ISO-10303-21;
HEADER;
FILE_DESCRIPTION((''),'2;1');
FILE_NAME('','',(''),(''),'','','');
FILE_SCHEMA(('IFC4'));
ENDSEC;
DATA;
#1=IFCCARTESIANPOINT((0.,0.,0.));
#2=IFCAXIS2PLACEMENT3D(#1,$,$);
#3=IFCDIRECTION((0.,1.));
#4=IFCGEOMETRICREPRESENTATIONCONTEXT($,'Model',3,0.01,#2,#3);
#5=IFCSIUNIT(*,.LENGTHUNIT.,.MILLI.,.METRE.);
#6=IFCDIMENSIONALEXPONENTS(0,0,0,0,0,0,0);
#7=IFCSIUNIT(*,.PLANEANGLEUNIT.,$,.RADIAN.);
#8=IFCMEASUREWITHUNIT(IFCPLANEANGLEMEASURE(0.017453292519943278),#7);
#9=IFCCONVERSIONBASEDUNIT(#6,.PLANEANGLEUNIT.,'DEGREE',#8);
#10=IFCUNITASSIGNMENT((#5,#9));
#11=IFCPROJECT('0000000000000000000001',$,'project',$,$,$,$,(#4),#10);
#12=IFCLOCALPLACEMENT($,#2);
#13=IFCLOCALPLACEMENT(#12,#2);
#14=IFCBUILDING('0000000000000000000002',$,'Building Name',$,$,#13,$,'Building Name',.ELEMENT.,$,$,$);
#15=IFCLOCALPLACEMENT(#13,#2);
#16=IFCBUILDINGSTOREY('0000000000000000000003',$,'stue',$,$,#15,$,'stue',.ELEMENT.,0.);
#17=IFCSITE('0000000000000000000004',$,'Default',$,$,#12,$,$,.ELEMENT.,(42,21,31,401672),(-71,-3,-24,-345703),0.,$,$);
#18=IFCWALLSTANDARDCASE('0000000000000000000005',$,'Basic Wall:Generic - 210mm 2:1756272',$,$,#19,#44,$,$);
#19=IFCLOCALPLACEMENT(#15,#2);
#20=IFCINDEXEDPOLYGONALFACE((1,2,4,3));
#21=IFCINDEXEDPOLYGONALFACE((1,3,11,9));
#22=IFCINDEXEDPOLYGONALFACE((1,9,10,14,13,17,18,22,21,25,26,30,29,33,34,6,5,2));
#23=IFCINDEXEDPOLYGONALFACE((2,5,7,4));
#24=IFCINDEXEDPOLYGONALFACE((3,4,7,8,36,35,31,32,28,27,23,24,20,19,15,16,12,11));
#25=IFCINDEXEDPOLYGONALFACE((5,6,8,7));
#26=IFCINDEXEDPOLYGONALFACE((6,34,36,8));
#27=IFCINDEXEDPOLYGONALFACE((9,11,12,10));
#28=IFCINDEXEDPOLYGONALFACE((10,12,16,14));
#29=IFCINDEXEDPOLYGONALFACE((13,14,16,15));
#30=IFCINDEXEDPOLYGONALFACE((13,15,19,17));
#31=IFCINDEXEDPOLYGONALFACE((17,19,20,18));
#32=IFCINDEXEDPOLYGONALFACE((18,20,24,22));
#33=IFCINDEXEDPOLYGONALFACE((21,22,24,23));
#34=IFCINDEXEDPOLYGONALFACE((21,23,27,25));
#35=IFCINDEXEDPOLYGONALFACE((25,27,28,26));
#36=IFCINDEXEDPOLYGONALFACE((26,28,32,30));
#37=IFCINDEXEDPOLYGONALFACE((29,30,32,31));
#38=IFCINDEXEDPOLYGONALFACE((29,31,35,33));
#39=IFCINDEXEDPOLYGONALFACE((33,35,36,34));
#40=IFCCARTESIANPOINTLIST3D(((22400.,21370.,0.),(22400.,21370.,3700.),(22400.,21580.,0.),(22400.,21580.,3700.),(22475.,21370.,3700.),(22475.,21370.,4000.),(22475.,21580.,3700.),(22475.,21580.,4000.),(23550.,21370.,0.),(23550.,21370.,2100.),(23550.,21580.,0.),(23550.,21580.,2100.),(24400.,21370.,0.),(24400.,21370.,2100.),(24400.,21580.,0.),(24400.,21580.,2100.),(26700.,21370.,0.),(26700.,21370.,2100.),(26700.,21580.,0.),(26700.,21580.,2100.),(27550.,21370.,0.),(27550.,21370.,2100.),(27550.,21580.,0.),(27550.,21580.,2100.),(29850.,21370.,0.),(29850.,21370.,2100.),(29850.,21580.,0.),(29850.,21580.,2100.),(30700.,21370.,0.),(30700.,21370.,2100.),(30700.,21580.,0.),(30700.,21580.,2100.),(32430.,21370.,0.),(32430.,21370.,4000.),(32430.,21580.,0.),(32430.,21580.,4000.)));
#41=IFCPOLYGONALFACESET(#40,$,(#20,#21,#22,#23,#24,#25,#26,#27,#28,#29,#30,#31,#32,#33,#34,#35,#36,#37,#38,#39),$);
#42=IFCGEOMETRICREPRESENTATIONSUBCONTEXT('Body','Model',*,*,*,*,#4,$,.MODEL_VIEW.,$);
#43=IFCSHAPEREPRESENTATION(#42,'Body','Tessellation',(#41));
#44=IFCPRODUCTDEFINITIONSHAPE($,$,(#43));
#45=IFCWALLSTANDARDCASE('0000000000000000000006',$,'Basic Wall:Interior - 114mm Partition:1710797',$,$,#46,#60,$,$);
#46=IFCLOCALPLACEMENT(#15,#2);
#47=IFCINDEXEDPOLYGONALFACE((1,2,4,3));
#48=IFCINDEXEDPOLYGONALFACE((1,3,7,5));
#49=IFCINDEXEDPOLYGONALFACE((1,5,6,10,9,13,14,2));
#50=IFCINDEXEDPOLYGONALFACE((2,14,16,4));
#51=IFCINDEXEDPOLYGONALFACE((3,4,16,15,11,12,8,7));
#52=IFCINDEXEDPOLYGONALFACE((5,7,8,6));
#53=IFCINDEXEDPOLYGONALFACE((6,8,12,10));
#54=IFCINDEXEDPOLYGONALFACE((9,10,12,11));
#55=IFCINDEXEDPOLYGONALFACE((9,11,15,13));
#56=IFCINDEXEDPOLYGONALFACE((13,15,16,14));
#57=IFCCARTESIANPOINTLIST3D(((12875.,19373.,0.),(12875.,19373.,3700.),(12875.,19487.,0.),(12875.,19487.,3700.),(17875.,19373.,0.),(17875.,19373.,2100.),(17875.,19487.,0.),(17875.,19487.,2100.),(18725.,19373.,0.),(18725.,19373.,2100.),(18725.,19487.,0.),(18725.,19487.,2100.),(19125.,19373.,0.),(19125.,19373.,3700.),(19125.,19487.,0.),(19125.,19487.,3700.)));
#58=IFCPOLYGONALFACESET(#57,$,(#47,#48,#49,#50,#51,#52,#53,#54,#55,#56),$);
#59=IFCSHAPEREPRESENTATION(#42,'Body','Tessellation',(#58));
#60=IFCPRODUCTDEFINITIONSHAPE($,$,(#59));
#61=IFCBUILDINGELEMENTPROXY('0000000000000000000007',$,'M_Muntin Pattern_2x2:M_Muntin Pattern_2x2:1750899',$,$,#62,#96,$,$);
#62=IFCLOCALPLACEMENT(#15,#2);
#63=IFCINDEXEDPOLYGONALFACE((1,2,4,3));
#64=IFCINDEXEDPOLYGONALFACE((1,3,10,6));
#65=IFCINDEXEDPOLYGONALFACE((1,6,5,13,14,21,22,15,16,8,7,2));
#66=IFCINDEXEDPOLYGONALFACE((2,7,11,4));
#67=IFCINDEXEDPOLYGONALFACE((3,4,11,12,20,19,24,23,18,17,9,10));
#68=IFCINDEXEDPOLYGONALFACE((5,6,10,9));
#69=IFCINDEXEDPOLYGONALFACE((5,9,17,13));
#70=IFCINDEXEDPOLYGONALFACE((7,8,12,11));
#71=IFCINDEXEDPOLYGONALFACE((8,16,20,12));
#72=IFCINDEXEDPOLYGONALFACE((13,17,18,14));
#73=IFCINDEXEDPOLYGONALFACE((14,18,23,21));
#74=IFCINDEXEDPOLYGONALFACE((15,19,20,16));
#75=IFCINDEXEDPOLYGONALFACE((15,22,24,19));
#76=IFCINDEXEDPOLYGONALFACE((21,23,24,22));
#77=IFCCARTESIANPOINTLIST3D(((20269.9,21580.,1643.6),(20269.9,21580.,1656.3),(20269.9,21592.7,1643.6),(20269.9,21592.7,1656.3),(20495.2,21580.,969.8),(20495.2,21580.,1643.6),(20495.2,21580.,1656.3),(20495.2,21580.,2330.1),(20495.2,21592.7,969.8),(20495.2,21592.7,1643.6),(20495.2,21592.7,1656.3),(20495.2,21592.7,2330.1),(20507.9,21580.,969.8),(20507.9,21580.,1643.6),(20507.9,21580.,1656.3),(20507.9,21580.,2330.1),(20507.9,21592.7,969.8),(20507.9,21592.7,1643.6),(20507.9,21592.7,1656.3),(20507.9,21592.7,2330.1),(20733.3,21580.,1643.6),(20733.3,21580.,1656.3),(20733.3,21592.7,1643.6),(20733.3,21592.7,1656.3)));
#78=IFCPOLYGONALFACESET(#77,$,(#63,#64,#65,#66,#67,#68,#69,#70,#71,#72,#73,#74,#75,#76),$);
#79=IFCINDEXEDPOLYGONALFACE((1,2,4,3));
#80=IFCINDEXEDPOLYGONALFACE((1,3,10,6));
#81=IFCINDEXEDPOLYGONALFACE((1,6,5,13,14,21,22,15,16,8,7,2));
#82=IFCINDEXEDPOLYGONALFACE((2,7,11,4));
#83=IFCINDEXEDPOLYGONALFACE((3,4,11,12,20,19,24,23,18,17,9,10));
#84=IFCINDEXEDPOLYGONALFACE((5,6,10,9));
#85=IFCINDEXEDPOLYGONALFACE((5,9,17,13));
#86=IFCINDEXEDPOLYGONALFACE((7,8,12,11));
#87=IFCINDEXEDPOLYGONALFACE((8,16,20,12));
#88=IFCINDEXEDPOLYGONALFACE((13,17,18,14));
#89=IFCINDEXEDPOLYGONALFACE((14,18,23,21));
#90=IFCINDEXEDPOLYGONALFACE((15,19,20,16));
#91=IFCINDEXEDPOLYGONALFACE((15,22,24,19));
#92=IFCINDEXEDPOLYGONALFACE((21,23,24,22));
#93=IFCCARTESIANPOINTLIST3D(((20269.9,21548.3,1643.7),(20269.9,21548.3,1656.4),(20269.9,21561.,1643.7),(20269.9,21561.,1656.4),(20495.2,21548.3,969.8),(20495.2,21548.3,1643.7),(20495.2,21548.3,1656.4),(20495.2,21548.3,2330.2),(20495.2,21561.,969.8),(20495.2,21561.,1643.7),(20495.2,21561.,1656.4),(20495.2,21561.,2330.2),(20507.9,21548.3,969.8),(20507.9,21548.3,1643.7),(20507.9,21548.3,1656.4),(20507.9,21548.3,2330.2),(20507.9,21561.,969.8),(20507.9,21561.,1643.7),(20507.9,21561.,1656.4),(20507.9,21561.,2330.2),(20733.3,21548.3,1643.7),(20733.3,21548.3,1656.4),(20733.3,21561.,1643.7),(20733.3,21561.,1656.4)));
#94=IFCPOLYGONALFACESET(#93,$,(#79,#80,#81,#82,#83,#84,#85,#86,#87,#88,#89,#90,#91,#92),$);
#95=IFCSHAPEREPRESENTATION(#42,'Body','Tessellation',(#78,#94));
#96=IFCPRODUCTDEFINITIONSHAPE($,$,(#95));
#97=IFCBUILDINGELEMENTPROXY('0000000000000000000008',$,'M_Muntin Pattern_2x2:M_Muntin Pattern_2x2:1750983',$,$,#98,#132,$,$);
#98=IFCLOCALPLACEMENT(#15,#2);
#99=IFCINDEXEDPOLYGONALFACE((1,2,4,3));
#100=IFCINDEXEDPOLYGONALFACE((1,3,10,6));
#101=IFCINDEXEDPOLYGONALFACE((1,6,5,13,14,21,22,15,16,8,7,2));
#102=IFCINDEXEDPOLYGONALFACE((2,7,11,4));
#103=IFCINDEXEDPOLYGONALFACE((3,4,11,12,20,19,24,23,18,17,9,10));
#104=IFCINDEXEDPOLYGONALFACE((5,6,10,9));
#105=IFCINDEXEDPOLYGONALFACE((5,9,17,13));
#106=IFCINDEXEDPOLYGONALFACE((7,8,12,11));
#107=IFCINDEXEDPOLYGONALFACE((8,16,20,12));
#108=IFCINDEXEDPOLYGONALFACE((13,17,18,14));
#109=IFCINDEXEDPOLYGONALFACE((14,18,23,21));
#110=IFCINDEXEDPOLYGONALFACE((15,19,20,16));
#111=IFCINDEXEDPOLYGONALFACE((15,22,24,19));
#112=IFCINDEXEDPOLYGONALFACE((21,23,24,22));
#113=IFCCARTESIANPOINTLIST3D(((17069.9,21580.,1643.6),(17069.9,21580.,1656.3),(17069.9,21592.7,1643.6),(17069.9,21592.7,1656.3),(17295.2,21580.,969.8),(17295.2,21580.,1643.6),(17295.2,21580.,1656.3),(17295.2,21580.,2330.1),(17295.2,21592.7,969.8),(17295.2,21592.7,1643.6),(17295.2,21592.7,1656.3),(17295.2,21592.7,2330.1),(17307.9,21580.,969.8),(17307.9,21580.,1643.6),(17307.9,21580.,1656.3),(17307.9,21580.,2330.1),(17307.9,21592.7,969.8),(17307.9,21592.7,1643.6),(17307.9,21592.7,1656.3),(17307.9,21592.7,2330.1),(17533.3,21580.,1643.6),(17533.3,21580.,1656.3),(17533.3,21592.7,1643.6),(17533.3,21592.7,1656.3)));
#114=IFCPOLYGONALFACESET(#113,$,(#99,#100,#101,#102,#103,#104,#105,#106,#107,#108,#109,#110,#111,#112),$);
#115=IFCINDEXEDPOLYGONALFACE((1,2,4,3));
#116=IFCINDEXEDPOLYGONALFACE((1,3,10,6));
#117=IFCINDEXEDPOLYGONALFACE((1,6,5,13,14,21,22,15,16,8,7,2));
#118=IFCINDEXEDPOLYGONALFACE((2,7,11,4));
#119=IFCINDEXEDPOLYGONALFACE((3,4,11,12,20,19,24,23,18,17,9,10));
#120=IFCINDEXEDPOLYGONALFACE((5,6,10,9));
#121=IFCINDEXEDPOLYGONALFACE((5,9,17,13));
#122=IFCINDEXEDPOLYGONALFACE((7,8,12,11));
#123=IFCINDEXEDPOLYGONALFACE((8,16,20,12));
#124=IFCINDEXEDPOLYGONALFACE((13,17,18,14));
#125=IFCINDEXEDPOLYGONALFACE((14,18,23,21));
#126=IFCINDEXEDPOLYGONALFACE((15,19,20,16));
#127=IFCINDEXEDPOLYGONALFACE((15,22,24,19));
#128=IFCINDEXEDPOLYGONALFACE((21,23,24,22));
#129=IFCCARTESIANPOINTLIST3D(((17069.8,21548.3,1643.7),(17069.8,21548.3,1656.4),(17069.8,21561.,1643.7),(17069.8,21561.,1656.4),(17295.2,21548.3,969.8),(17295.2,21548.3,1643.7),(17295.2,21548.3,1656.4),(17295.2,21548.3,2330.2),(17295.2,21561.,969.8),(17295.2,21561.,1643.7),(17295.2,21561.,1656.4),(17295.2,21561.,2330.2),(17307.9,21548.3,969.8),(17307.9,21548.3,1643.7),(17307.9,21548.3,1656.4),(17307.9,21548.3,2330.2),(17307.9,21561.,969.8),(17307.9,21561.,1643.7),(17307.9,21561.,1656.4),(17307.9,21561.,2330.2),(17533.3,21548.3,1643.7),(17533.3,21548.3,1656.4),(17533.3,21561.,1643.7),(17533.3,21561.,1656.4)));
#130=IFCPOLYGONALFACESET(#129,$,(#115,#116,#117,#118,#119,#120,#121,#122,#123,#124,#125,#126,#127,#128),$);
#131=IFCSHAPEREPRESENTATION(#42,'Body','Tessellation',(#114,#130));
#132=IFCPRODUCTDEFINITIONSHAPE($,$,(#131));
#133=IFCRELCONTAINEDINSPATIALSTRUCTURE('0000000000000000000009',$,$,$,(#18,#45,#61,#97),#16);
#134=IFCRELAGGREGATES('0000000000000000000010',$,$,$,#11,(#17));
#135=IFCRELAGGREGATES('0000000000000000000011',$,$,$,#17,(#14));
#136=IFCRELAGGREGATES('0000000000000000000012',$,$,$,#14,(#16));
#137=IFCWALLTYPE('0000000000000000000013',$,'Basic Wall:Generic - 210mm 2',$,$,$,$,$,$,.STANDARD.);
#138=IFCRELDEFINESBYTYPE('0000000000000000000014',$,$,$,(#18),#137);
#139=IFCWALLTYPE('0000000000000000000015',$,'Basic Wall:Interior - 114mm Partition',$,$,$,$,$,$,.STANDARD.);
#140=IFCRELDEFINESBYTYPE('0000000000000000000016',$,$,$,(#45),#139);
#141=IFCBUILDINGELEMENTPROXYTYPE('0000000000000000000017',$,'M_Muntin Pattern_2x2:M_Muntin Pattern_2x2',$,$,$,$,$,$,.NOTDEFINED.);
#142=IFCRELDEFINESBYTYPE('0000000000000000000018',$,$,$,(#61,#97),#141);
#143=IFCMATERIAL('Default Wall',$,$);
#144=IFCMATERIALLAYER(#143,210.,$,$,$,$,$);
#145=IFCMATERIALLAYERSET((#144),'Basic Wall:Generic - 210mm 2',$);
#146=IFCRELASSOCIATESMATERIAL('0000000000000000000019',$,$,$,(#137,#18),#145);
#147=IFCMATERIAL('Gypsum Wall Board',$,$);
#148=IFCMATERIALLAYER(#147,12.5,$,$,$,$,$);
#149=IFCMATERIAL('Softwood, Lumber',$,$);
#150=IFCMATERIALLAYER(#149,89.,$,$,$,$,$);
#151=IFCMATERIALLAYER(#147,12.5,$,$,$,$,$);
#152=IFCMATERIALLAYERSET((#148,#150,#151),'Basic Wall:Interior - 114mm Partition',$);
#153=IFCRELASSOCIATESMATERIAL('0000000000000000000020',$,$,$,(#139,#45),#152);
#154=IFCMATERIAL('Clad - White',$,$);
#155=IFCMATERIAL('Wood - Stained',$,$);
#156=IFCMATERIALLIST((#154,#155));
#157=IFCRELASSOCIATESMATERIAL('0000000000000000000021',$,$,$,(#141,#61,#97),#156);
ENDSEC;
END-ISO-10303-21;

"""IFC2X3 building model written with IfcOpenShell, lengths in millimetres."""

from ifc_helpers import new_model, entity, si_unit, converted_unit, direction, frame, frame_2d, origin, place, context, subcontext, project, spatial, polyline, rectangle, outline, extrude, clip, bounded_halfspace, source, transform, mapped, material, material_list, layer, layer_set, layer_usage, type_object, type_shapes, element, save


model = new_model("IFC2X3")

# Units and contexts
model_context = context("Model", 3, precision=0.01, world=origin(), true_north=direction((0.0, 1.0)))
body_context = subcontext(model_context, "Body", "Model", "MODEL_VIEW")
ifc_project = project(units=[si_unit("LENGTHUNIT", "METRE", prefix="MILLI"), converted_unit("PLANEANGLEUNIT", "DEGREE", entity("IfcPlaneAngleMeasure", 0.017453292519943278), si_unit("PLANEANGLEUNIT", "RADIAN"), dimensions=[0, 0, 0, 0, 0, 0, 0])], contexts=[model_context])

# Site, building, storey
site_placement = place(None, origin())
site = spatial("IfcSite", under=ifc_project, at=site_placement, Name="Default", CompositionType="ELEMENT", RefLatitude=(42, 21, 31, 401672), RefLongitude=(-71, -3, -24, -345703), RefElevation=0.0)
building_placement = place(site_placement, origin())
building = spatial("IfcBuilding", under=site, at=building_placement, Name="Building Name", LongName="Building Name", CompositionType="ELEMENT")
storey_placement = place(building_placement, origin())
storey = spatial("IfcBuildingStorey", under=building, at=storey_placement, Name="stue", LongName="stue", CompositionType="ELEMENT", Elevation=0.0)

# Shared definitions
ifc_material_1 = material(Name="Default Wall")

# Wall, openings
ifc_material_2 = material(Name="Gypsum Wall Board")
ifc_layer_1 = layer(ifc_material_1, 210.0)
ifc_layer_set_1 = layer_set([ifc_layer_1], Name="Basic Wall:Generic - 210mm 2")
ifc_layer_usage_1 = layer_usage(ifc_layer_set_1, "AXIS2", "NEGATIVE", 105.0)
wall_type_1 = type_object("IfcWallType", Name="Basic Wall:Generic - 210mm 2", PredefinedType="STANDARD", material=ifc_layer_set_1)
wall_1_placement = place(storey_placement, frame((22400.0, 21475.0, 0.0)))
wall_1 = element("IfcWallStandardCase", 1, at=wall_1_placement, inside=storey, type_object=wall_type_1, material=ifc_layer_usage_1, Name="Basic Wall:Generic - 210mm 2:1756272", context=body_context, shape_type="Clipping", body=[
    clip(extrude(rectangle(XDim=10030.0, YDim=210.0, at=frame_2d((5015.0, 0.0), x_axis=(-1.0, 0.0))), origin(), (0.0, 0.0, 1.0), 4000.0), bounded_halfspace(frame((0.0, -105.0, 3700.0), z_axis=(0.0, 0.0, -1.0), x_axis=(0.0, -1.0, 0.0)), True, frame((0.0, -105.0, 3700.0)), polyline([(0.0, 0.0), (75.0, 0.0), (75.0, 210.0), (0.0, 210.0), (0.0, 0.0)]))),
])
opening_1_placement = place(wall_1_placement, frame((7450.0, -105.0, 0.0)))
element("IfcOpeningElement", 2, at=opening_1_placement, cuts=wall_1, ObjectType="Opening", context=body_context, shape_type="SweptSolid", body=[
    extrude(rectangle(XDim=2100.0, YDim=850.0, at=frame_2d((1050.0, 425.0), x_axis=(1.0, 0.0))), frame((0.0, 0.0, 0.0), z_axis=(0.0, 1.0, 0.0), x_axis=(0.0, 0.0, 1.0)), (0.0, 0.0, 1.0), 210.0),
])
opening_2_placement = place(wall_1_placement, frame((-22400.0, -21475.0, 0.0)))
element("IfcOpeningElement", 3, at=opening_2_placement, cuts=wall_1, ObjectType="Opening", context=body_context, shape_type="SweptSolid", body=[
    extrude(rectangle(XDim=2100.0, YDim=850.0, at=frame_2d((0.0, 0.0), x_axis=(1.0, 0.0))), frame((30275.0, 19846.0, 1050.0), z_axis=(0.0, 1.0, 0.0), x_axis=(0.0, 0.0, 1.0)), (0.0, 0.0, 1.0), 3048.0),
])
opening_3_placement = place(wall_1_placement, frame((4300.0, -105.0, 0.0)))
element("IfcOpeningElement", 4, at=opening_3_placement, cuts=wall_1, ObjectType="Opening", context=body_context, shape_type="SweptSolid", body=[
    extrude(rectangle(XDim=2100.0, YDim=850.0, at=frame_2d((1050.0, 425.0), x_axis=(1.0, 0.0))), frame((0.0, 0.0, 0.0), z_axis=(0.0, 1.0, 0.0), x_axis=(0.0, 0.0, 1.0)), (0.0, 0.0, 1.0), 210.0),
])
opening_4_placement = place(wall_1_placement, frame((-22400.0, -21475.0, 0.0)))
element("IfcOpeningElement", 5, at=opening_4_placement, cuts=wall_1, ObjectType="Opening", context=body_context, shape_type="SweptSolid", body=[
    extrude(rectangle(XDim=2100.0, YDim=850.0, at=frame_2d((0.0, 0.0), x_axis=(1.0, 0.0))), frame((27125.0, 19846.0, 1050.0), z_axis=(0.0, 1.0, 0.0), x_axis=(0.0, 0.0, 1.0)), (0.0, 0.0, 1.0), 3048.0),
])
opening_5_placement = place(wall_1_placement, frame((1150.0, -105.0, 0.0)))
element("IfcOpeningElement", 6, at=opening_5_placement, cuts=wall_1, ObjectType="Opening", context=body_context, shape_type="SweptSolid", body=[
    extrude(rectangle(XDim=2100.0, YDim=850.0, at=frame_2d((1050.0, 425.0), x_axis=(1.0, 0.0))), frame((0.0, 0.0, 0.0), z_axis=(0.0, 1.0, 0.0), x_axis=(0.0, 0.0, 1.0)), (0.0, 0.0, 1.0), 210.0),
])
opening_6_placement = place(wall_1_placement, frame((-22400.0, -21475.0, 0.0)))
element("IfcOpeningElement", 7, at=opening_6_placement, cuts=wall_1, ObjectType="Opening", context=body_context, shape_type="SweptSolid", body=[
    extrude(rectangle(XDim=2100.0, YDim=850.0, at=frame_2d((0.0, 0.0), x_axis=(1.0, 0.0))), frame((23975.0, 19846.0, 1050.0), z_axis=(0.0, 1.0, 0.0), x_axis=(0.0, 0.0, 1.0)), (0.0, 0.0, 1.0), 3048.0),
])

# Wall, opening
ifc_layer_2 = layer(ifc_material_2, 12.5)
ifc_material_3 = material(Name="Softwood, Lumber")
ifc_layer_3 = layer(ifc_material_3, 89.0)
ifc_layer_4 = layer(ifc_material_2, 12.5)
ifc_layer_set_2 = layer_set([ifc_layer_2, ifc_layer_3, ifc_layer_4], Name="Basic Wall:Interior - 114mm Partition")
ifc_layer_usage_2 = layer_usage(ifc_layer_set_2, "AXIS2", "NEGATIVE", 57.0)
wall_type_2 = type_object("IfcWallType", Name="Basic Wall:Interior - 114mm Partition", PredefinedType="STANDARD", material=ifc_layer_set_2)
wall_2_placement = place(storey_placement, frame((12875.0, 19430.0, 0.0)))
wall_2 = element("IfcWallStandardCase", 8, at=wall_2_placement, inside=storey, type_object=wall_type_2, material=ifc_layer_usage_2, Name="Basic Wall:Interior - 114mm Partition:1710797", context=body_context, shape_type="Clipping", body=[
    clip(extrude(rectangle(XDim=6250.0, YDim=114.0, at=frame_2d((3125.0, 0.0), x_axis=(-1.0, 0.0))), origin(), (0.0, 0.0, 1.0), 3700.0), bounded_halfspace(frame((0.0, -57.0, 3700.0), z_axis=(0.0, 0.0, -1.0), x_axis=(0.0, -1.0, 0.0)), True, frame((0.0, -57.0, 3700.0)), polyline([(0.0, 0.0), (6250.0, 0.0), (6250.0, 114.0), (0.0, 114.0), (0.0, 0.0)]))),
])
opening_7_placement = place(wall_2_placement, frame((5000.0, -57.0, 0.0)))
element("IfcOpeningElement", 9, at=opening_7_placement, cuts=wall_2, ObjectType="Opening", context=body_context, shape_type="SweptSolid", body=[
    extrude(rectangle(XDim=2100.0, YDim=850.0, at=frame_2d((1050.0, 425.0), x_axis=(1.0, 0.0))), frame((0.0, 0.0, 0.0), z_axis=(0.0, 1.0, 0.0), x_axis=(0.0, 0.0, 1.0)), (0.0, 0.0, 1.0), 114.0),
])

# Building element proxies
ifc_material_4 = material(Name="Clad - White")
ifc_material_5 = material(Name="Wood - Stained")
ifc_material_list = material_list([ifc_material_4, ifc_material_5])
building_element_proxy_type_1 = type_object("IfcBuildingElementProxyType", Name="M_Muntin Pattern_2x2:M_Muntin Pattern_2x2", PredefinedType="NOTDEFINED", material=ifc_material_list)
shared_shape_1 = source(origin(), body_context, "Body", "SweptSolid", [
    extrude(outline(polyline([(6.4, -6.4), (680.1, -6.4), (680.1, 6.3), (6.4, 6.3), (6.4, 231.7), (-6.3, 231.7), (-6.3, 6.3), (-680.2, 6.3), (-680.2, -6.4), (-6.3, -6.4), (-6.3, -231.7), (6.4, -231.7), (6.4, -6.4)])), frame((0.0, 9.5, 680.1), z_axis=(0.0, 1.0, 0.0), x_axis=(0.0, 0.0, 1.0)), (0.0, 0.0, 1.0), 12.7),
    extrude(outline(polyline([(6.4, -6.4), (680.2, -6.4), (680.2, 6.3), (6.4, 6.3), (6.4, 231.7), (-6.3, 231.7), (-6.3, 6.3), (-680.2, 6.3), (-680.2, -6.4), (-6.3, -6.4), (-6.3, -231.7), (6.4, -231.7), (6.4, -6.4)])), frame((0.0, -22.2, 680.2), z_axis=(0.0, 1.0, 0.0), x_axis=(0.0, 0.0, 1.0)), (0.0, 0.0, 1.0), 12.7),
])
type_shapes(building_element_proxy_type_1, [shared_shape_1])
for number, where, name in (
    (10, (20501.6, 21570.5, 969.8), "M_Muntin Pattern_2x2:M_Muntin Pattern_2x2:1750899"),
    (11, (17301.6, 21570.5, 969.8), "M_Muntin Pattern_2x2:M_Muntin Pattern_2x2:1750983"),
):
    element("IfcBuildingElementProxy", number, at=place(storey_placement, frame(where)), inside=storey, type_object=building_element_proxy_type_1, material=ifc_material_list, Name=name, context=body_context, shape_type="MappedRepresentation", body=[
        mapped(shared_shape_1, transform((0.0, 0.0, 0.0), scale=1.0)),
    ])

save(model, "model.ifc")
